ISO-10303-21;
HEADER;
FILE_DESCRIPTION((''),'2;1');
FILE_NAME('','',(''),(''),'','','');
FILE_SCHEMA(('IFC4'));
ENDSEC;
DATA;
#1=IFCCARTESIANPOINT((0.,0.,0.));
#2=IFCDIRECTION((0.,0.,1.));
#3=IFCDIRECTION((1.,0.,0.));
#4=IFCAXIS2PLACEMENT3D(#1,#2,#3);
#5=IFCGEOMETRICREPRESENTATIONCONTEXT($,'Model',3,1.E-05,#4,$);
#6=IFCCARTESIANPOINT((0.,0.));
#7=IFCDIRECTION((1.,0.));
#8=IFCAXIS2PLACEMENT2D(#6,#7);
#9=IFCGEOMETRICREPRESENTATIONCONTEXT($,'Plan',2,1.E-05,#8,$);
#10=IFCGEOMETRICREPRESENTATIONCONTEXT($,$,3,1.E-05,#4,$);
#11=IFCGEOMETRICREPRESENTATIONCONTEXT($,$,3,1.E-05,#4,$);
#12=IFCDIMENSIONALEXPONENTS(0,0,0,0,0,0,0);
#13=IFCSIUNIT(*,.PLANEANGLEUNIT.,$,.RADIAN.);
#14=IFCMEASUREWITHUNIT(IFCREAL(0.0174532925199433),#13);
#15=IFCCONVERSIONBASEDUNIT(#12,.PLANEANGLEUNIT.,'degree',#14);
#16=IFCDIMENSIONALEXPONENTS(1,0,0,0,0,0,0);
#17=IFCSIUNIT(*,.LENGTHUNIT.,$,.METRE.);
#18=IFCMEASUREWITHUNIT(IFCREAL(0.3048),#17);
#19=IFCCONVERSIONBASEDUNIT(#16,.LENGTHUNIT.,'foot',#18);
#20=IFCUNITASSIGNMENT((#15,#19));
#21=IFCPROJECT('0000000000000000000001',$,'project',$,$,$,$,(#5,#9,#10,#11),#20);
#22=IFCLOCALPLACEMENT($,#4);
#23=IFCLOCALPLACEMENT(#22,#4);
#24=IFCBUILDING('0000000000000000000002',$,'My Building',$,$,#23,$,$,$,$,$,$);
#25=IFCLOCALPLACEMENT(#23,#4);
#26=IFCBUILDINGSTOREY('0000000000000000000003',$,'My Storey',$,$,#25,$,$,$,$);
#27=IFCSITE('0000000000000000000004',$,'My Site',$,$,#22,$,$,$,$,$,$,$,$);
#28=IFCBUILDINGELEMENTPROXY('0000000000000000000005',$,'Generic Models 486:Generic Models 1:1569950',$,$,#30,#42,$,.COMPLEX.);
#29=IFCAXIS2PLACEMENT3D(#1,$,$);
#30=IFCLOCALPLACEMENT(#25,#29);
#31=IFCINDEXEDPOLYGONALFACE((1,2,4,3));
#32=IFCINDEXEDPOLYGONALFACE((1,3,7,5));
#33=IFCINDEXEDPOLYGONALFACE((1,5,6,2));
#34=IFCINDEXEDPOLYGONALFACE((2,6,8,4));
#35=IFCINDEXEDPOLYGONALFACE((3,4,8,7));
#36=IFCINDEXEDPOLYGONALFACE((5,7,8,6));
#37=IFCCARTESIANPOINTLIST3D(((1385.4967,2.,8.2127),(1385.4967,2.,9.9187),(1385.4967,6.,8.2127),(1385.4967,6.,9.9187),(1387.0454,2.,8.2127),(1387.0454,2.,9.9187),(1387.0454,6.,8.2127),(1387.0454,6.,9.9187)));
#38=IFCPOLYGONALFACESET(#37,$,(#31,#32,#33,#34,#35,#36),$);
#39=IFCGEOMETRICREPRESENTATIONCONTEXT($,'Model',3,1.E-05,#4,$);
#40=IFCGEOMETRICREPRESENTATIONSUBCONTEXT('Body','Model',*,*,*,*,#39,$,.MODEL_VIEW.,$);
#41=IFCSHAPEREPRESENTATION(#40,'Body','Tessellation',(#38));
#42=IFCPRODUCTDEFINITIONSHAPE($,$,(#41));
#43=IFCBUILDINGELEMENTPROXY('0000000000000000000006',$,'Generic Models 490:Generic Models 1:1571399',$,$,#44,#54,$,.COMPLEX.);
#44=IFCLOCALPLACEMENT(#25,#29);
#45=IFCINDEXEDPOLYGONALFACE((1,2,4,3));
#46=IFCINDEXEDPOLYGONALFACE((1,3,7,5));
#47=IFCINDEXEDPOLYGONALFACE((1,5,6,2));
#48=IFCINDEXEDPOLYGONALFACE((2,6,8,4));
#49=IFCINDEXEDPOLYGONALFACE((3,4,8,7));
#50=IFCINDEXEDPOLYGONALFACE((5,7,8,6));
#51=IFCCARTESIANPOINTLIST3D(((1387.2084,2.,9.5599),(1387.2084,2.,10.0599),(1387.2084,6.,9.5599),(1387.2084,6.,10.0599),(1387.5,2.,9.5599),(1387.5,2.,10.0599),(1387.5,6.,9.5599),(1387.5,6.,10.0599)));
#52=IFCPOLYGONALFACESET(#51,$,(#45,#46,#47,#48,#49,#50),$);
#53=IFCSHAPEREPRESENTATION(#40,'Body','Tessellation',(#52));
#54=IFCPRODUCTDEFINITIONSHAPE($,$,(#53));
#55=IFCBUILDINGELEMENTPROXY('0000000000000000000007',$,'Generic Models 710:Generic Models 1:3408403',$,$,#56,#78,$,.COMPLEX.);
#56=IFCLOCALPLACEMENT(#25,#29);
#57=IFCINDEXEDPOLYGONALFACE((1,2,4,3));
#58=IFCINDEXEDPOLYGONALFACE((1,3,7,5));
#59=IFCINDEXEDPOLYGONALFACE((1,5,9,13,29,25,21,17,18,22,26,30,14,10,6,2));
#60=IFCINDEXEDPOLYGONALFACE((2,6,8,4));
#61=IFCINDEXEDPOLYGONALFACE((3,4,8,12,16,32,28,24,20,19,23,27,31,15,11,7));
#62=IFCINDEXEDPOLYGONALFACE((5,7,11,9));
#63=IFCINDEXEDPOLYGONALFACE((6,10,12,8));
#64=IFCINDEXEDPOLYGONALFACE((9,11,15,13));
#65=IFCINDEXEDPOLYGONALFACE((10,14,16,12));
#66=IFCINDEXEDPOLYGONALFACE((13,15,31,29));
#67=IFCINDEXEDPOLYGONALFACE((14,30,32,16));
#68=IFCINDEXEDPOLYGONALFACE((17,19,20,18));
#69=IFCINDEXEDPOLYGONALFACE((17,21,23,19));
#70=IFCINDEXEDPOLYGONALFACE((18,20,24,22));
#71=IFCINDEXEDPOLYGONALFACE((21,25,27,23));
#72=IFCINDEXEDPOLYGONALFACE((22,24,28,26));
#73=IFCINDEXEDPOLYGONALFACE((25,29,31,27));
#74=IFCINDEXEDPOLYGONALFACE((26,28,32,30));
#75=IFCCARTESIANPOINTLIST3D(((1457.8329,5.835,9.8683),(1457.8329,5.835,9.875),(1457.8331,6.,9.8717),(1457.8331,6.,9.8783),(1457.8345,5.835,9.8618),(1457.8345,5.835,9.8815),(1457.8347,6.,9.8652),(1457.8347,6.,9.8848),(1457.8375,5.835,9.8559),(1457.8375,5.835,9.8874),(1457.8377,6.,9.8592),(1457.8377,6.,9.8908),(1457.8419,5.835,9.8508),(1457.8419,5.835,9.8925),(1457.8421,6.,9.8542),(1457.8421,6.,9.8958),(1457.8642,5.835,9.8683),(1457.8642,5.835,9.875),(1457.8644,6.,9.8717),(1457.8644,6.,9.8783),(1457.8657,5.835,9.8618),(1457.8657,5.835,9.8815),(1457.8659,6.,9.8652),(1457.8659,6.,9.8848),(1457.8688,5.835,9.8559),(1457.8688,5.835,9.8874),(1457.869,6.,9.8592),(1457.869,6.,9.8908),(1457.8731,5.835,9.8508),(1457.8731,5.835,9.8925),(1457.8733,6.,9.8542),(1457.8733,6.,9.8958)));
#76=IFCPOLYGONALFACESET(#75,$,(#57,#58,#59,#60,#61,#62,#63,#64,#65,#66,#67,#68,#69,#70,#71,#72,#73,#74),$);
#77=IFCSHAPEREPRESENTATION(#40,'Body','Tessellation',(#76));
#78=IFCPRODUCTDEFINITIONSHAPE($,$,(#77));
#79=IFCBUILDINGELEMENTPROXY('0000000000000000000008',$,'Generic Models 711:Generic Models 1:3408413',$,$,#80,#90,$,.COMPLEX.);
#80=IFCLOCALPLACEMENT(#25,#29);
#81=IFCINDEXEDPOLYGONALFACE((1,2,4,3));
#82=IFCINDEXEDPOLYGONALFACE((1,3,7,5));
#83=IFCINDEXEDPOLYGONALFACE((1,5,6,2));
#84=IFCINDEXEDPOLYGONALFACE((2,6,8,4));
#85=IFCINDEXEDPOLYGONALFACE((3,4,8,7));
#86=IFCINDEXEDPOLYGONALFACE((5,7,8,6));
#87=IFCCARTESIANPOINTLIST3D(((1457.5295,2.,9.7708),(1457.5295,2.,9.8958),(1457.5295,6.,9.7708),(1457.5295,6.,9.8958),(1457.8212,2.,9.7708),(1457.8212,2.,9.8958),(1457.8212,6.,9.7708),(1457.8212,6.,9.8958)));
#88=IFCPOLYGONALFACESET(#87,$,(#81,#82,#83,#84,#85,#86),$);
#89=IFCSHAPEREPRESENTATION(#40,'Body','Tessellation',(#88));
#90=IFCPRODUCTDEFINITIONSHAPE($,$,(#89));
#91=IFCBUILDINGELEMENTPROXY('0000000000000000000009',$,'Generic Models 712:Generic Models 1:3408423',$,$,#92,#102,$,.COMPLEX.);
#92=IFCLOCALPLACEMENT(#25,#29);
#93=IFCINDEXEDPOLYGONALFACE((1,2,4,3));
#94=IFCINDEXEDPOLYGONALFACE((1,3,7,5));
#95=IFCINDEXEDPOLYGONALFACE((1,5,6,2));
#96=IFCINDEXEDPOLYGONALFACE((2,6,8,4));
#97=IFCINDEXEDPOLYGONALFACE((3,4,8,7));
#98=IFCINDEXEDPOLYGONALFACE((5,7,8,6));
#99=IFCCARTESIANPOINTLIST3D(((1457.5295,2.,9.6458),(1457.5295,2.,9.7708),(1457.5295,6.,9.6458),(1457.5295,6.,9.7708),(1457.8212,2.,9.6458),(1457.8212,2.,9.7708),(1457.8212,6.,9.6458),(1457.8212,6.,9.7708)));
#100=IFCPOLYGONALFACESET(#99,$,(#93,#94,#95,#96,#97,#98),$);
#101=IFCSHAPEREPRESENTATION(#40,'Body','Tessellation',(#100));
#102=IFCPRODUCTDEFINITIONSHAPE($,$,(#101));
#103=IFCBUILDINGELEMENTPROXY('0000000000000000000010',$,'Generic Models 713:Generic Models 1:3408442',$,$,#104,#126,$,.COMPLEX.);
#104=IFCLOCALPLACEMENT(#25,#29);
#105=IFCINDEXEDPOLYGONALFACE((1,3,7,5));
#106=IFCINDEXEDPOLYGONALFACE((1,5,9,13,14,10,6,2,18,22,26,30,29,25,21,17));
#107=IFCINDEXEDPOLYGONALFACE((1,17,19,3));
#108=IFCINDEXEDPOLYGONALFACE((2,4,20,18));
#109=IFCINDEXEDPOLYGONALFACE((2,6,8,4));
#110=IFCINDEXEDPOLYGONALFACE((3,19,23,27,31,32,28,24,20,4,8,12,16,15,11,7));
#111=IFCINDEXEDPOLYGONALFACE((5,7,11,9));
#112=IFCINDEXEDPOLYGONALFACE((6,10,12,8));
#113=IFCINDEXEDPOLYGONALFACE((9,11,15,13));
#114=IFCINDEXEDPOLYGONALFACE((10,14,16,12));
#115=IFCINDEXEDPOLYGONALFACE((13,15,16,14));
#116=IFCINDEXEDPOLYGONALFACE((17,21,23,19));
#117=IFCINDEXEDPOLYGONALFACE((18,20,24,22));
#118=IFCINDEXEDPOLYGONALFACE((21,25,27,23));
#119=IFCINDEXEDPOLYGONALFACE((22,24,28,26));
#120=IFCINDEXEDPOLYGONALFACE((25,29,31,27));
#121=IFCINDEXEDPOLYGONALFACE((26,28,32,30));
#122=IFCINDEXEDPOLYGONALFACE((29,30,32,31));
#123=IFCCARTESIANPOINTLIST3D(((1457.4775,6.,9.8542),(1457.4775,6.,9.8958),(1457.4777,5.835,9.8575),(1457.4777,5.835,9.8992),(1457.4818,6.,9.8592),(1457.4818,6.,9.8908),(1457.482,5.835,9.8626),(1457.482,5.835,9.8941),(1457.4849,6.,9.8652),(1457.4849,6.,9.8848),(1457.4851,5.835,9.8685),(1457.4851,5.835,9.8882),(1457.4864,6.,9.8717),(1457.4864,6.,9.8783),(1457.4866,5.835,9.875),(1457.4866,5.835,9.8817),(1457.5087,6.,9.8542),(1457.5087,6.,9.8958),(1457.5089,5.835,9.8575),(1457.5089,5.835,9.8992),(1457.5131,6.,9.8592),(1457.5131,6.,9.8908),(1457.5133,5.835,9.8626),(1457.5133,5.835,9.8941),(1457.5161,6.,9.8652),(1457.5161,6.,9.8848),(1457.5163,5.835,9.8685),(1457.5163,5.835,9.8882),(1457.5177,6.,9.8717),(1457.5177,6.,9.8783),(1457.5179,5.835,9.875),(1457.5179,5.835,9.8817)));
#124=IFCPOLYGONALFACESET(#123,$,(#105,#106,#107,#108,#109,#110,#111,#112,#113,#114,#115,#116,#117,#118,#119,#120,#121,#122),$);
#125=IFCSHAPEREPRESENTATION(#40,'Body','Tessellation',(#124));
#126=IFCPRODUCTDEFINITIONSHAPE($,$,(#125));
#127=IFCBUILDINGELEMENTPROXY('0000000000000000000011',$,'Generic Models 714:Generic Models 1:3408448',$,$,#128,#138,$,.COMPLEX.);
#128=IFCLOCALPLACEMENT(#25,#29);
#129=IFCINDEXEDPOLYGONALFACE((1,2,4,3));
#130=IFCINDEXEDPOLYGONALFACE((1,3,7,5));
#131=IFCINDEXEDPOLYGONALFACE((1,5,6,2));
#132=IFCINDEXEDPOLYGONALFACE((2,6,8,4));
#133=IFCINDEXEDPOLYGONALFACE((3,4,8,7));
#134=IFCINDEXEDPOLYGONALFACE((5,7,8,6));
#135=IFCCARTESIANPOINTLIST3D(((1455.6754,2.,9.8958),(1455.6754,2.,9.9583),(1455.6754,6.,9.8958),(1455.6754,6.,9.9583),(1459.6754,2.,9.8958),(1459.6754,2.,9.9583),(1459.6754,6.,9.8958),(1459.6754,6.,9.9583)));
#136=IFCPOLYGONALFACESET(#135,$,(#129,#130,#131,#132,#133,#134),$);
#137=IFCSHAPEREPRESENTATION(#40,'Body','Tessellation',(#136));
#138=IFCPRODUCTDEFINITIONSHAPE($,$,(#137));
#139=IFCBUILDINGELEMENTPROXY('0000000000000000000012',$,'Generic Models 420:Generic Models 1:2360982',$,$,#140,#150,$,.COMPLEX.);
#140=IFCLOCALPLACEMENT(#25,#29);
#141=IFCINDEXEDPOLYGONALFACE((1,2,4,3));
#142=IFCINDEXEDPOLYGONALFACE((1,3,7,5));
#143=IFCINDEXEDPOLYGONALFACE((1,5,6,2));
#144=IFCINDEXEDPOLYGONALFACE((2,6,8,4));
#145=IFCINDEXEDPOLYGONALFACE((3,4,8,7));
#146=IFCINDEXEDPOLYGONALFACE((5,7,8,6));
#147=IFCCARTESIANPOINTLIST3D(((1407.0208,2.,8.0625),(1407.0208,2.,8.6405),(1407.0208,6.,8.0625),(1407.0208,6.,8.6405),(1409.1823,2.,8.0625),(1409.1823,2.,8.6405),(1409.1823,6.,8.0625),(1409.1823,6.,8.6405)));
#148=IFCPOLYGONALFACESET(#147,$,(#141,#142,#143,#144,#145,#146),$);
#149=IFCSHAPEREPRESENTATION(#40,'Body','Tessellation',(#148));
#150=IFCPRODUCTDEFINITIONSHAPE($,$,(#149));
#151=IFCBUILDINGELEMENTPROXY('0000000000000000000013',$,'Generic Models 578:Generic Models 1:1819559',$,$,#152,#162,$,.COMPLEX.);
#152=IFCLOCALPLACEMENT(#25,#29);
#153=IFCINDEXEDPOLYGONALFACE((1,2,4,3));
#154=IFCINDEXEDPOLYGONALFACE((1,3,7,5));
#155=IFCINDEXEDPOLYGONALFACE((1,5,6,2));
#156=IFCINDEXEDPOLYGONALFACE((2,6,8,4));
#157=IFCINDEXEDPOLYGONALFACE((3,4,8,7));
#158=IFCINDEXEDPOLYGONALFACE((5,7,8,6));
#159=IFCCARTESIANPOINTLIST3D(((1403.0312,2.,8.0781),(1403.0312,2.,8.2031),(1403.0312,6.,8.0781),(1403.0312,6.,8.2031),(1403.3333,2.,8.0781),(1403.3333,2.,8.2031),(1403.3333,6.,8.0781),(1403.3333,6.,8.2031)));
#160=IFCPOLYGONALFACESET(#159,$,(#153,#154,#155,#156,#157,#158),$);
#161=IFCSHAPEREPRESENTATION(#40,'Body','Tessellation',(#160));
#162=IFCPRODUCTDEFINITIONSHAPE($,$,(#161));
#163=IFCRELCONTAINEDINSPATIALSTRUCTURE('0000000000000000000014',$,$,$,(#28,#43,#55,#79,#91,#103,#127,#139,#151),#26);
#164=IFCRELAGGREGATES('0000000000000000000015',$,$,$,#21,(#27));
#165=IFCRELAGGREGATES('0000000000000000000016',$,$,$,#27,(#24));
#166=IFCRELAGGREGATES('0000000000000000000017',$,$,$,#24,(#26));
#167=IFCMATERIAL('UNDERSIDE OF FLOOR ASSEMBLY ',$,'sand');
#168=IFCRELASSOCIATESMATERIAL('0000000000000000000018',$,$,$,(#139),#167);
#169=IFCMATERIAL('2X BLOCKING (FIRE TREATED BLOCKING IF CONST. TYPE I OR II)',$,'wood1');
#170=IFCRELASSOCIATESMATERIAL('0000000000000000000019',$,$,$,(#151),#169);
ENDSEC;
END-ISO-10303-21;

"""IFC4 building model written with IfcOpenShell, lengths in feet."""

from ifc_helpers import new_model, entity, si_unit, converted_unit, frame, origin_with_axes, origin_2d_with_axis, place, context, subcontext, project, spatial, polyline, line, indexed_curve, outline, extrude, material, element, save


model = new_model("IFC4")

# Units and contexts
model_context_1 = context("Model", 3, precision=1e-05, world=origin_with_axes())
plan_context = context("Plan", 2, precision=1e-05, world=origin_2d_with_axis())
model_context_2 = context("Model", 3, precision=1e-05, world=origin_with_axes())
context_of_model_1 = context(None, 3, precision=1e-05, world=origin_with_axes())
context_of_model_2 = context(None, 3, precision=1e-05, world=origin_with_axes())
body_context = subcontext(model_context_2, "Body", "Model", "MODEL_VIEW")
ifc_project = project(units=[converted_unit("PLANEANGLEUNIT", "degree", entity("IfcReal", 0.0174532925199433), si_unit("PLANEANGLEUNIT", "RADIAN"), dimensions=[0, 0, 0, 0, 0, 0, 0]), converted_unit("LENGTHUNIT", "foot", entity("IfcReal", 0.3048), si_unit("LENGTHUNIT", "METRE"), dimensions=[1, 0, 0, 0, 0, 0, 0])], contexts=[model_context_1, plan_context, context_of_model_1, context_of_model_2])

# Site, building, storey
site_placement = place(None, origin_with_axes())
site = spatial("IfcSite", under=ifc_project, at=site_placement, Name="My Site")
building_placement = place(site_placement, origin_with_axes())
building = spatial("IfcBuilding", under=site, at=building_placement, Name="My Building")
storey_placement = place(building_placement, origin_with_axes())
storey = spatial("IfcBuildingStorey", under=building, at=storey_placement, Name="My Storey")

# Building element proxies
proxy_1_placement = place(storey_placement, frame((1385.4967, 6.0, 8.2127), z_axis=(0.0, -1.0, 0.0), x_axis=(0.0, 0.0, 1.0)))
element("IfcBuildingElementProxy", 1, at=proxy_1_placement, inside=storey, Name="Generic Models 486:Generic Models 1:1569950", PredefinedType="COMPLEX", context=body_context, shape_type="SweptSolid", body=[
    extrude(outline(polyline([(-0.853, -0.7743), (0.853, -0.7743), (0.853, 0.7743), (-0.853, 0.7743), (-0.853, -0.7743)])), frame((0.853, -0.7743, 0.0), z_axis=(0.0, 0.0, -1.0), x_axis=(-1.0, 0.0, 0.0)), (0.0, 0.0, -1.0), 4.0),
])
proxy_2_placement = place(storey_placement, frame((1387.2084, 6.0, 9.5599), z_axis=(0.0, -1.0, 0.0), x_axis=(0.0, 0.0, 1.0)))
element("IfcBuildingElementProxy", 2, at=proxy_2_placement, inside=storey, Name="Generic Models 490:Generic Models 1:1571399", PredefinedType="COMPLEX", context=body_context, shape_type="SweptSolid", body=[
    extrude(outline(polyline([(-0.25, -0.1458), (0.25, -0.1458), (0.25, 0.1458), (-0.25, 0.1458), (-0.25, -0.1458)])), frame((0.25, -0.1458, 0.0), z_axis=(0.0, 0.0, -1.0), x_axis=(-1.0, 0.0, 0.0)), (0.0, 0.0, -1.0), 4.0),
])
proxy_3_placement = place(storey_placement, frame((1457.8331, 6.0, 9.8542), z_axis=(0.0, -1.0, 0.0), x_axis=(0.0, 0.0, 1.0)))
element("IfcBuildingElementProxy", 3, at=proxy_3_placement, inside=storey, Name="Generic Models 710:Generic Models 1:3408403", PredefinedType="COMPLEX", context=body_context, shape_type="SweptSolid", body=[
    extrude(outline(polyline([(0.0166, 0.0), (0.0115, 0.0043), (0.0076, 0.0097), (0.005, 0.0159), (0.0039, 0.0224), (0.0045, 0.0291), (-0.0207, 0.0106), (-0.0213, 0.004), (-0.0202, -0.0026), (-0.0176, -0.0088), (-0.0137, -0.0142), (-0.0086, -0.0185), (-0.0026, -0.0215), (0.0039, -0.023), (0.0291, -0.0045), (0.0226, -0.003), (0.0166, 0.0)])), frame((0.0208, -0.0194, 0.0), z_axis=(0.0, 0.0, -1.0), x_axis=(0.591192, -0.806531, 0.0)), (-0.012926, 0.015608, -0.999795), 0.165),
])
proxy_4_placement = place(storey_placement, frame((1457.5295, 6.0, 9.7708), z_axis=(0.0, -1.0, 0.0), x_axis=(0.0, 0.0, 1.0)))
element("IfcBuildingElementProxy", 4, at=proxy_4_placement, inside=storey, Name="Generic Models 711:Generic Models 1:3408413", PredefinedType="COMPLEX", context=body_context, shape_type="SweptSolid", body=[
    extrude(outline(polyline([(-0.0625, -0.1458), (0.0625, -0.1458), (0.0625, 0.1458), (-0.0625, 0.1458), (-0.0625, -0.1458)])), frame((0.0625, -0.1458, 0.0), z_axis=(0.0, 0.0, -1.0), x_axis=(-1.0, 0.0, 0.0)), (0.0, 0.0, -1.0), 4.0),
])
proxy_5_placement = place(storey_placement, frame((1457.5295, 6.0, 9.6458), z_axis=(0.0, -1.0, 0.0), x_axis=(0.0, 0.0, 1.0)))
element("IfcBuildingElementProxy", 5, at=proxy_5_placement, inside=storey, Name="Generic Models 712:Generic Models 1:3408423", PredefinedType="COMPLEX", context=body_context, shape_type="SweptSolid", body=[
    extrude(outline(polyline([(-0.0625, -0.1458), (0.0625, -0.1458), (0.0625, 0.1458), (-0.0625, 0.1458), (-0.0625, -0.1458)])), frame((0.0625, -0.1458, 0.0), z_axis=(0.0, 0.0, -1.0), x_axis=(1.0, 0.0, 0.0)), (0.0, 0.0, -1.0), 4.0),
])
proxy_6_placement = place(storey_placement, frame((1457.4775, 6.0, 9.8542), z_axis=(0.0, -1.0, 0.0), x_axis=(0.0, 0.0, 1.0)))
element("IfcBuildingElementProxy", 6, at=proxy_6_placement, inside=storey, Name="Generic Models 713:Generic Models 1:3408442", PredefinedType="COMPLEX", context=body_context, shape_type="SweptSolid", body=[
    extrude(outline(polyline([(0.0166, 0.0), (0.0226, 0.003), (0.0291, 0.0045), (0.0039, 0.023), (-0.0026, 0.0215), (-0.0086, 0.0185), (-0.0137, 0.0142), (-0.0176, 0.0088), (-0.0202, 0.0026), (-0.0213, -0.004), (-0.0207, -0.0106), (0.0045, -0.0291), (0.0039, -0.0224), (0.005, -0.0159), (0.0076, -0.0097), (0.0115, -0.0043), (0.0166, 0.0)])), frame((0.0208, -0.0208, 0.0), z_axis=(0.0, 0.0, -1.0), x_axis=(0.591192, 0.806531, 0.0)), (0.010994, 0.017024, -0.999795), 0.165),
])
proxy_7_placement = place(storey_placement, frame((1455.6754, 6.0, 9.8958), z_axis=(0.0, -1.0, 0.0), x_axis=(0.0, 0.0, 1.0)))
element("IfcBuildingElementProxy", 7, at=proxy_7_placement, inside=storey, Name="Generic Models 714:Generic Models 1:3408448", PredefinedType="COMPLEX", context=body_context, shape_type="SweptSolid", body=[
    extrude(outline(indexed_curve([(-0.0313, -2.0), (0.0312, -2.0), (0.0313, 2.0), (-0.0312, 2.0)], segments=[line(4, 1), line(1, 2), line(2, 3), line(3, 4)], self_intersect=False)), frame((0.0313, -2.0, 0.0), z_axis=(0.0, 0.0, -1.0), x_axis=(-1.0, 0.0, 0.0)), (0.0, 0.0, -1.0), 4.0),
])
ifc_material_1 = material(Name="UNDERSIDE OF FLOOR ASSEMBLY ", Category="sand")
proxy_8_placement = place(storey_placement, frame((1407.0208, 6.0, 8.0625), z_axis=(0.0, -1.0, 0.0), x_axis=(0.0, 0.0, 1.0)))
element("IfcBuildingElementProxy", 8, at=proxy_8_placement, inside=storey, material=ifc_material_1, Name="Generic Models 420:Generic Models 1:2360982", PredefinedType="COMPLEX", context=body_context, shape_type="SweptSolid", body=[
    extrude(outline(polyline([(-0.289, -1.0807), (0.289, -1.0807), (0.289, 1.0807), (-0.289, 1.0807), (-0.289, -1.0807)])), frame((0.289, -1.0807, 0.0), z_axis=(0.0, 0.0, -1.0), x_axis=(1.0, 0.0, 0.0)), (0.0, 0.0, -1.0), 4.0),
])
ifc_material_2 = material(Name="2X BLOCKING (FIRE TREATED BLOCKING IF CONST. TYPE I OR II)", Category="wood1")
proxy_9_placement = place(storey_placement, frame((1403.0312, 6.0, 8.0781), z_axis=(0.0, -1.0, 0.0), x_axis=(0.0, 0.0, 1.0)))
element("IfcBuildingElementProxy", 9, at=proxy_9_placement, inside=storey, material=ifc_material_2, Name="Generic Models 578:Generic Models 1:1819559", PredefinedType="COMPLEX", context=body_context, shape_type="SweptSolid", body=[
    extrude(outline(polyline([(-0.0625, -0.151), (0.0625, -0.151), (0.0625, 0.151), (-0.0625, 0.151), (-0.0625, -0.151)])), frame((0.0625, -0.151, 0.0), z_axis=(0.0, 0.0, -1.0), x_axis=(-1.0, 0.0, 0.0)), (0.0, 0.0, -1.0), 4.0),
])

save(model, "model.ifc")
